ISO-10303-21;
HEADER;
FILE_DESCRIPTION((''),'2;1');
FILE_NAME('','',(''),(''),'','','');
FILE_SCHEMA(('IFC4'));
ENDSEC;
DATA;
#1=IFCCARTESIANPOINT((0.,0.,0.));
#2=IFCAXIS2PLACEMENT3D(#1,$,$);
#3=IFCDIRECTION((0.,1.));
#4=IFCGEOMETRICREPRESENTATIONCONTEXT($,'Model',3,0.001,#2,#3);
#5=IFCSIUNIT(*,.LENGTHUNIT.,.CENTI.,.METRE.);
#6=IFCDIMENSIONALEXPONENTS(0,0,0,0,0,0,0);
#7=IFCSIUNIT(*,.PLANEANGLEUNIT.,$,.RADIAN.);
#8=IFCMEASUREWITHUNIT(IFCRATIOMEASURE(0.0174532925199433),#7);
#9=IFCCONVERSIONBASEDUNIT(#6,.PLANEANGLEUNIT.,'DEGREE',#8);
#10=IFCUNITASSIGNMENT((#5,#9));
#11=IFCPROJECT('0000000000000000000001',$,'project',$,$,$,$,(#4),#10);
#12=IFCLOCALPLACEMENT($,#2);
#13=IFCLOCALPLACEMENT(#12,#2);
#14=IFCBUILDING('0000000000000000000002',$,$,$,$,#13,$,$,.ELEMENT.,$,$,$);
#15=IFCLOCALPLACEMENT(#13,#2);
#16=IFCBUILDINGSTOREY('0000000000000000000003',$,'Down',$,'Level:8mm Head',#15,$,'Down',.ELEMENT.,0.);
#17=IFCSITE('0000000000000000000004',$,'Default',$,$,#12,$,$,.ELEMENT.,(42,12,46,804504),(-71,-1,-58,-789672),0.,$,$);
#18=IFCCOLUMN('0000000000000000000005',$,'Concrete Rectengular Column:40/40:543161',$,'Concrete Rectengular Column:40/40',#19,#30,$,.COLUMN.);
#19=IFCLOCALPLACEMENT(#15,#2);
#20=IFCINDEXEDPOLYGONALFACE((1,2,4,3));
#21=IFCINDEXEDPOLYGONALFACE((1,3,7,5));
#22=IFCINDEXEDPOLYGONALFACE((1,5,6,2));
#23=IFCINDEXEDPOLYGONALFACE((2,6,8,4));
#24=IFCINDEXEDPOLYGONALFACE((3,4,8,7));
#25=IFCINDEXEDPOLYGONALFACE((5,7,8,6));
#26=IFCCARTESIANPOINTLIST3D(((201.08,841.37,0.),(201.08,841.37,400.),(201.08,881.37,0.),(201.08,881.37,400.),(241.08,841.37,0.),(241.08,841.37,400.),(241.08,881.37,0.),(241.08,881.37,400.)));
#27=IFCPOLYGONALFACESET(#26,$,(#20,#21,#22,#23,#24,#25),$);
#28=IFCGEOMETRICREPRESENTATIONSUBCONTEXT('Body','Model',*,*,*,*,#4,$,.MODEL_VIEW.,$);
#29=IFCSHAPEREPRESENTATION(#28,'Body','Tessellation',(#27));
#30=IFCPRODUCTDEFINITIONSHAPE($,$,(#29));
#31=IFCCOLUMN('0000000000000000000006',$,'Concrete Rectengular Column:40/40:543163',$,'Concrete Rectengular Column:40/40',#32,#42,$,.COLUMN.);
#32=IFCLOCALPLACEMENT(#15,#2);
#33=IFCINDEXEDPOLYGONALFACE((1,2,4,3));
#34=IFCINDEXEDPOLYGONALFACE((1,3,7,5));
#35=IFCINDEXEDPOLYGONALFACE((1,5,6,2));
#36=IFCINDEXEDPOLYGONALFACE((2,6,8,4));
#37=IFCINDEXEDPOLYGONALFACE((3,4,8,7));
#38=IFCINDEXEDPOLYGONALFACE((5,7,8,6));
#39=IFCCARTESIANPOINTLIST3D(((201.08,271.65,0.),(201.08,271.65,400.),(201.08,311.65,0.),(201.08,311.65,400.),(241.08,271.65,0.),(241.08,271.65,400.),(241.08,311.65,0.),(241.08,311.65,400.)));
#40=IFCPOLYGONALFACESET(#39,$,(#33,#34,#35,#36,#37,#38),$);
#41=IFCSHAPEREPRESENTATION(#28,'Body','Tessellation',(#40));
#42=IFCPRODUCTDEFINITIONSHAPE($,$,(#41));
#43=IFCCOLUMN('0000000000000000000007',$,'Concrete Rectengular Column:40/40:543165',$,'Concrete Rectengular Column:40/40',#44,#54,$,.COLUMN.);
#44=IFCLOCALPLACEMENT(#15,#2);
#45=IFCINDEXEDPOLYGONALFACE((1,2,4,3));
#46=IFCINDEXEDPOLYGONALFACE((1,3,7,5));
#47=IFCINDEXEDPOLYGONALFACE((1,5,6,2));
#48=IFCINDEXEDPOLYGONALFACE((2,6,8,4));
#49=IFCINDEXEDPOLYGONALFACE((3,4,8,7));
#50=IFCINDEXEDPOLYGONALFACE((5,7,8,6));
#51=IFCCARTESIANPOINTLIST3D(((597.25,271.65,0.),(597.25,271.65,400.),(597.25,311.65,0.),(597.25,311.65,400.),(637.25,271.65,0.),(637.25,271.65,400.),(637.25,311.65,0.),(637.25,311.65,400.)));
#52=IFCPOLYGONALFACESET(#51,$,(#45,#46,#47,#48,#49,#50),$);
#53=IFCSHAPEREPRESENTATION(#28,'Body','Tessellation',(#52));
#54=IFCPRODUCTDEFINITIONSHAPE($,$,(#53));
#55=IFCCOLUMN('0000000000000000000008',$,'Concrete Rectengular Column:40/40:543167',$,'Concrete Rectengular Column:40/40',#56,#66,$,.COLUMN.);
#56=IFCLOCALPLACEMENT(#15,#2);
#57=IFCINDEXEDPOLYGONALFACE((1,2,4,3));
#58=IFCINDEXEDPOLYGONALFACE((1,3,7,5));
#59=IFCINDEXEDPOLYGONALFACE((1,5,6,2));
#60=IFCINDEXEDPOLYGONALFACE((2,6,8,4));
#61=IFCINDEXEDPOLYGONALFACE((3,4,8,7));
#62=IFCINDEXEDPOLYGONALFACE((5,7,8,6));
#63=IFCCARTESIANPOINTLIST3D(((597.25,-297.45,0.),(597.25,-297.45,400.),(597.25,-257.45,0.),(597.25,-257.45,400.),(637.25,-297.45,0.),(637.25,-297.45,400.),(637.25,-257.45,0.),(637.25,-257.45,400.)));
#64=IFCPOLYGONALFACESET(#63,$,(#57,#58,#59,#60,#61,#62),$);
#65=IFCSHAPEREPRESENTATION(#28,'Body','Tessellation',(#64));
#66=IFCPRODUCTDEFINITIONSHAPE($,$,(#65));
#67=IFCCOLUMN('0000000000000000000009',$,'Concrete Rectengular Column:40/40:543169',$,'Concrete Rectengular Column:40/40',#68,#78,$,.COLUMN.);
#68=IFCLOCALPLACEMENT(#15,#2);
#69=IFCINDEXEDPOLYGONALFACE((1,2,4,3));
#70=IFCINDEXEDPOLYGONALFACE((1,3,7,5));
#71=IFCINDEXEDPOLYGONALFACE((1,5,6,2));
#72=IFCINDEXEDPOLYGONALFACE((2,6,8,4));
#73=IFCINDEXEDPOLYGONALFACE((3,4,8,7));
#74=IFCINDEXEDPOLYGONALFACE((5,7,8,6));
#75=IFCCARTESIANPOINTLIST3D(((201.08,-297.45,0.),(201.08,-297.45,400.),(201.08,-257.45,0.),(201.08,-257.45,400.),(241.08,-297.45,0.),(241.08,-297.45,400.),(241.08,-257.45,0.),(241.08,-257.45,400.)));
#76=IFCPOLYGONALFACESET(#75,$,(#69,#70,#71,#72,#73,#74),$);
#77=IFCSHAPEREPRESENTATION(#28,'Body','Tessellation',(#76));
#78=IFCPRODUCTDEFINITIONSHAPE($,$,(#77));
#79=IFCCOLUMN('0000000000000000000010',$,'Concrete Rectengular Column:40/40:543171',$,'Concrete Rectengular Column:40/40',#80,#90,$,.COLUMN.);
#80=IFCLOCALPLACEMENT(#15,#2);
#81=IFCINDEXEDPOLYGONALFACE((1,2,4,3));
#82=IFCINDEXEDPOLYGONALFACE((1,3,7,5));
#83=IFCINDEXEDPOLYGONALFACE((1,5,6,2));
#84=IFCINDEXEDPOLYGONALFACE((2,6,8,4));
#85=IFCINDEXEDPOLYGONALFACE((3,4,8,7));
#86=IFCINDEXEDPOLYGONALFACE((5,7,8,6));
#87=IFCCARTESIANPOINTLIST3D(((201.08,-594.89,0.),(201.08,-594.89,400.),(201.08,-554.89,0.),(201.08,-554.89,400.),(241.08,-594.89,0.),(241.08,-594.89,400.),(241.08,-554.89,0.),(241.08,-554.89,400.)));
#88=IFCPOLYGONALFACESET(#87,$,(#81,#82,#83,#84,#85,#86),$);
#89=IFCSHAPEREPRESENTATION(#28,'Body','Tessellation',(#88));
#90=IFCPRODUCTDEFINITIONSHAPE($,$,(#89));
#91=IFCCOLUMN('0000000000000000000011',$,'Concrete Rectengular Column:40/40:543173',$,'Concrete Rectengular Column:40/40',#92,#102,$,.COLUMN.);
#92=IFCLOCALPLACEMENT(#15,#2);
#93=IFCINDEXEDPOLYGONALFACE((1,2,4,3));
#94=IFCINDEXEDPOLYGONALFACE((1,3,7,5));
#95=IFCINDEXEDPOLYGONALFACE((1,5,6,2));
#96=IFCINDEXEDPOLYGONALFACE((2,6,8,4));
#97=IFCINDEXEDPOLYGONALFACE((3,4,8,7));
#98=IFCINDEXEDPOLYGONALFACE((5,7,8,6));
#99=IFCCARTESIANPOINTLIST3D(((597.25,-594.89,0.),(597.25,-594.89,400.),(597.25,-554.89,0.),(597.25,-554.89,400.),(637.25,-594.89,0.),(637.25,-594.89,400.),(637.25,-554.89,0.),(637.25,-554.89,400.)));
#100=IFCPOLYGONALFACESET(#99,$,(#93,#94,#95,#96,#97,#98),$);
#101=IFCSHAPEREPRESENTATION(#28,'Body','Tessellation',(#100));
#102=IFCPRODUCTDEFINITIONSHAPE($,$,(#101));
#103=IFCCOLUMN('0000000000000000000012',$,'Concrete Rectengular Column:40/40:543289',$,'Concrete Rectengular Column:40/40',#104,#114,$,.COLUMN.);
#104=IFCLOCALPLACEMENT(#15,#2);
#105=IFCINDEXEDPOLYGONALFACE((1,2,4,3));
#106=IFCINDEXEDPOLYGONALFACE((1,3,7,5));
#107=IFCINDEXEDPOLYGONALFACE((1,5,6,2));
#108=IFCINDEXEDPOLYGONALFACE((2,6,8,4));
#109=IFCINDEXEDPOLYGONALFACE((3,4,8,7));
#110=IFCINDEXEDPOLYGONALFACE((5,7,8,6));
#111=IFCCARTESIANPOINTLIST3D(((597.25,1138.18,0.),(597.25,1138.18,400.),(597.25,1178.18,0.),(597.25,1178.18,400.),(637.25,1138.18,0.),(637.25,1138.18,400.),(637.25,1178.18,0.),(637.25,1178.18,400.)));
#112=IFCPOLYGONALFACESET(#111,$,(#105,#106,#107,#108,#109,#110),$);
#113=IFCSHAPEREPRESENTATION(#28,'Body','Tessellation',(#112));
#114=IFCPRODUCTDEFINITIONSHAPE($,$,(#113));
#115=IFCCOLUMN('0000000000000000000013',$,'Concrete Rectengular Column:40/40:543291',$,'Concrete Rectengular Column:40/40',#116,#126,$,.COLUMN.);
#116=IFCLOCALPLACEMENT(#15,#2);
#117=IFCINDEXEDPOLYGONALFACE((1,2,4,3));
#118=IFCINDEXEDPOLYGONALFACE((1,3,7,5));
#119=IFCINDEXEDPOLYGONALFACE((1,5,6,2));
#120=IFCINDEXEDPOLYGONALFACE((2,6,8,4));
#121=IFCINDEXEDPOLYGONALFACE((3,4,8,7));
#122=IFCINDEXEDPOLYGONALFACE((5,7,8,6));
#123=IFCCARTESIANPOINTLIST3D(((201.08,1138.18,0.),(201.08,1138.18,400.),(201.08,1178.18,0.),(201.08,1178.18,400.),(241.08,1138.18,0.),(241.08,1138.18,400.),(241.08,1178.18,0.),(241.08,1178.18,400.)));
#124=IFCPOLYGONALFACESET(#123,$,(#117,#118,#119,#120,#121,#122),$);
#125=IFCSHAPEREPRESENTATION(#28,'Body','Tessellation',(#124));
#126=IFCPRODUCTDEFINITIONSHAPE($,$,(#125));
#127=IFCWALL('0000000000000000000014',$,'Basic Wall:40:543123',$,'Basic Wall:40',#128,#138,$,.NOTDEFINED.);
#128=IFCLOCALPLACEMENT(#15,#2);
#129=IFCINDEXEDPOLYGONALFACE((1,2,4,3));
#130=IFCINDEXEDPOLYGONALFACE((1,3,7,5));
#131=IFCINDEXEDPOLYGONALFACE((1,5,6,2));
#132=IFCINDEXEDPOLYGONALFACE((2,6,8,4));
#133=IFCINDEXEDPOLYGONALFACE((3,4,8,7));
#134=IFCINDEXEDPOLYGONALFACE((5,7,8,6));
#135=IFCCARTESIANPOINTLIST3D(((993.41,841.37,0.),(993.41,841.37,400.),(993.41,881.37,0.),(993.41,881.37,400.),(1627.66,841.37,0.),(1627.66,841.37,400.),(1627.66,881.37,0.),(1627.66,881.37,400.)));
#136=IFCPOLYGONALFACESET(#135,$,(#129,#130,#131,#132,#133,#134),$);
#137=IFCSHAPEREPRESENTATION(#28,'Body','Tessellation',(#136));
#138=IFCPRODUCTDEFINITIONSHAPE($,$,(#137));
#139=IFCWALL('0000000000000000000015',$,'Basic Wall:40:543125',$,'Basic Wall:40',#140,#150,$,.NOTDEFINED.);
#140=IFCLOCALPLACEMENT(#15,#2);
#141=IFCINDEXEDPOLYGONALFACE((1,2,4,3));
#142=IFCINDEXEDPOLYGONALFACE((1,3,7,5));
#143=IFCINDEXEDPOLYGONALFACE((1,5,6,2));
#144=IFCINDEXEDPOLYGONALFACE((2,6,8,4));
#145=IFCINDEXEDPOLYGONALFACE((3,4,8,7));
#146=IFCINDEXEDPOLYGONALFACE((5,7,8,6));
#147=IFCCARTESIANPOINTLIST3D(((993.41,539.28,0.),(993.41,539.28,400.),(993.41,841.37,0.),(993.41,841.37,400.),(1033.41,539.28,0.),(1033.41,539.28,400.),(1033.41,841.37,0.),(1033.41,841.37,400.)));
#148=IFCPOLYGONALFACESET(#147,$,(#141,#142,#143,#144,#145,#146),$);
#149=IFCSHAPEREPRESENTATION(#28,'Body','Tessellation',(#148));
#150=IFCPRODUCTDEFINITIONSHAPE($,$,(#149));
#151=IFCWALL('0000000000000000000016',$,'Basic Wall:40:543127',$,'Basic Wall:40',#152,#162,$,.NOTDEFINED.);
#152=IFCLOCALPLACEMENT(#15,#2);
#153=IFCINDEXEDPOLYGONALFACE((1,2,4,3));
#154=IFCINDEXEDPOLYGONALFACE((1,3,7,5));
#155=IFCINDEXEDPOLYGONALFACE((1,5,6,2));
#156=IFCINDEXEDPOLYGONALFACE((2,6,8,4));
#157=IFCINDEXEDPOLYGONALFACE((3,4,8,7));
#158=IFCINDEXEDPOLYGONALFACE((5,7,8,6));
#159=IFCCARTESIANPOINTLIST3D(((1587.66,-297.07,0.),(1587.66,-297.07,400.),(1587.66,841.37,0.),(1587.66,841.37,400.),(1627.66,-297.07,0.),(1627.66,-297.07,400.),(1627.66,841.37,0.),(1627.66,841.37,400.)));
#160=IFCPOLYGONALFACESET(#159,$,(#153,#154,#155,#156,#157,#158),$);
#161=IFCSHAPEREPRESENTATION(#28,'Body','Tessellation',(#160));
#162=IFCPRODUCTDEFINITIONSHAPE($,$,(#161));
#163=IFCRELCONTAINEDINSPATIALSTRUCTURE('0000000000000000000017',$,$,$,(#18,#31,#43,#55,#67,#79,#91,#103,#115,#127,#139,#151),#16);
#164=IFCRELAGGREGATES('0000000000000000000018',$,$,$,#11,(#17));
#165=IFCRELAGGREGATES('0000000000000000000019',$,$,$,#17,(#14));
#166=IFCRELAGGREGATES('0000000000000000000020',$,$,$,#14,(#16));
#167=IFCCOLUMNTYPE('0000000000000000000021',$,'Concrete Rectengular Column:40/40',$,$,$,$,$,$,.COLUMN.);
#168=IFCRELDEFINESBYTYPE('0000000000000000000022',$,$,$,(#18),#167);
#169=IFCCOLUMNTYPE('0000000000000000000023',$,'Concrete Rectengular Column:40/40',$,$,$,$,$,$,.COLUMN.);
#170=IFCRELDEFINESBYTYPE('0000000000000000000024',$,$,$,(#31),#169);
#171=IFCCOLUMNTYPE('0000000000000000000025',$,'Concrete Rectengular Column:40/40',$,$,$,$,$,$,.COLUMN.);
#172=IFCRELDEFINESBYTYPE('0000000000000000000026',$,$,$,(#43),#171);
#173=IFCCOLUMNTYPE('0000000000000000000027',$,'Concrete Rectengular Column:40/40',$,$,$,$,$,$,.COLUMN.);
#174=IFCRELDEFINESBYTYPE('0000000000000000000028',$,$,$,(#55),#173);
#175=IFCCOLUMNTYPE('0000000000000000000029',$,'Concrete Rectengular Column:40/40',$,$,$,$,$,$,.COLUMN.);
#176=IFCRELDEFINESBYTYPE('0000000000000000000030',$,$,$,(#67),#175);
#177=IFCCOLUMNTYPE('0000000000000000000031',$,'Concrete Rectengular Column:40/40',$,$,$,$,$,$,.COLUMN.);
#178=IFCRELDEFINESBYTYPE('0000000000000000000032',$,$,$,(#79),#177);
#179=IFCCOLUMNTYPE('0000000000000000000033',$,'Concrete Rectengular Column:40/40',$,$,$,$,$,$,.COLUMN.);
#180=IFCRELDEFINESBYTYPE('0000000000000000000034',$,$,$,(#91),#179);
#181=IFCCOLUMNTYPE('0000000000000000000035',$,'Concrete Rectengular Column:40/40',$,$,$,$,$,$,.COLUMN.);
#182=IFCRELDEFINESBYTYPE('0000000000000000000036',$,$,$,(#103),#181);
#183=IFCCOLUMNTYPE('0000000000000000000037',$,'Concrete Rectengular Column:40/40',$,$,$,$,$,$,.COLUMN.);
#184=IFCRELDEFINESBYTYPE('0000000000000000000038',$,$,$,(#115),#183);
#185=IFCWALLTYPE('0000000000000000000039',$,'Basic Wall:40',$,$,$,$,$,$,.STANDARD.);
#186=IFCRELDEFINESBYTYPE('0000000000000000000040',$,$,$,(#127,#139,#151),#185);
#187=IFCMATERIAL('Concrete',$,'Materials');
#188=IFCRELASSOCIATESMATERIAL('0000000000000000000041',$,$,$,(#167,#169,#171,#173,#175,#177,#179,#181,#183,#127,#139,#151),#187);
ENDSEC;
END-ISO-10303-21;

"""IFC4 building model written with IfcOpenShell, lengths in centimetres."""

from ifc_helpers import new_model, entity, si_unit, converted_unit, direction, frame, origin, place, context, subcontext, project, spatial, indexed_curve, outline, extrude, source, transform, mapped, material, type_object, type_shapes, element, save


model = new_model("IFC4")

# Units and contexts
model_context = context("Model", 3, precision=0.001, world=origin(), true_north=direction((0.0, 1.0)))
body_context = subcontext(model_context, "Body", "Model", "MODEL_VIEW")
ifc_project = project(units=[si_unit("LENGTHUNIT", "METRE", prefix="CENTI"), converted_unit("PLANEANGLEUNIT", "DEGREE", entity("IfcRatioMeasure", 0.0174532925199433), si_unit("PLANEANGLEUNIT", "RADIAN"), dimensions=[0, 0, 0, 0, 0, 0, 0])], contexts=[model_context])

# Site, building, storey
site_placement = place(None, origin())
site = spatial("IfcSite", under=ifc_project, at=site_placement, Name="Default", CompositionType="ELEMENT", RefLatitude=(42, 12, 46, 804504), RefLongitude=(-71, -1, -58, -789672), RefElevation=0.0)
building_placement = place(site_placement, origin())
building = spatial("IfcBuilding", under=site, at=building_placement, CompositionType="ELEMENT")
storey_placement = place(building_placement, origin())
storey = spatial("IfcBuildingStorey", under=building, at=storey_placement, Name="Down", ObjectType="Level:8mm Head", LongName="Down", CompositionType="ELEMENT", Elevation=0.0)

# Columns
ifc_material = material(Name="Concrete", Category="Materials")
column_type_1 = type_object("IfcColumnType", Name="Concrete Rectengular Column:40/40", PredefinedType="COLUMN", material=ifc_material)
shared_shape_1 = source(origin(), body_context, "Body", "SweptSolid", [
    extrude(outline(indexed_curve([(-20.0, -20.0), (20.0, -20.0), (20.0, 20.0), (-20.0, 20.0), (-20.0, -20.0)], self_intersect=False)), frame((221.08, 861.37, 0.0), z_axis=(0.0, 0.0, 1.0), x_axis=(0.0, -1.0, 0.0)), (0.0, 0.0, 1.0), 400.0),
])
type_shapes(column_type_1, [shared_shape_1])
column_1_placement = place(storey_placement, origin())
element("IfcColumn", 1, at=column_1_placement, inside=storey, type_object=column_type_1, Name="Concrete Rectengular Column:40/40:543161", ObjectType="Concrete Rectengular Column:40/40", PredefinedType="COLUMN", context=body_context, shape_type="MappedRepresentation", body=[
    mapped(shared_shape_1, transform((0.0, 0.0, 0.0), scale=1.0)),
])
column_type_2 = type_object("IfcColumnType", Name="Concrete Rectengular Column:40/40", PredefinedType="COLUMN", material=ifc_material)
shared_shape_2 = source(origin(), body_context, "Body", "SweptSolid", [
    extrude(outline(indexed_curve([(-20.0, -20.0), (20.0, -20.0), (20.0, 20.0), (-20.0, 20.0), (-20.0, -20.0)], self_intersect=False)), frame((221.08, 291.65, 0.0), z_axis=(0.0, 0.0, 1.0), x_axis=(0.0, -1.0, 0.0)), (0.0, 0.0, 1.0), 400.0),
])
type_shapes(column_type_2, [shared_shape_2])
column_2_placement = place(storey_placement, origin())
element("IfcColumn", 2, at=column_2_placement, inside=storey, type_object=column_type_2, Name="Concrete Rectengular Column:40/40:543163", ObjectType="Concrete Rectengular Column:40/40", PredefinedType="COLUMN", context=body_context, shape_type="MappedRepresentation", body=[
    mapped(shared_shape_2, transform((0.0, 0.0, 0.0), scale=1.0)),
])
column_type_3 = type_object("IfcColumnType", Name="Concrete Rectengular Column:40/40", PredefinedType="COLUMN", material=ifc_material)
shared_shape_3 = source(origin(), body_context, "Body", "SweptSolid", [
    extrude(outline(indexed_curve([(-20.0, -20.0), (20.0, -20.0), (20.0, 20.0), (-20.0, 20.0), (-20.0, -20.0)], self_intersect=False)), frame((617.25, 291.65, 0.0), z_axis=(0.0, 0.0, 1.0), x_axis=(0.0, -1.0, 0.0)), (0.0, 0.0, 1.0), 400.0),
])
type_shapes(column_type_3, [shared_shape_3])
column_3_placement = place(storey_placement, origin())
element("IfcColumn", 3, at=column_3_placement, inside=storey, type_object=column_type_3, Name="Concrete Rectengular Column:40/40:543165", ObjectType="Concrete Rectengular Column:40/40", PredefinedType="COLUMN", context=body_context, shape_type="MappedRepresentation", body=[
    mapped(shared_shape_3, transform((0.0, 0.0, 0.0), scale=1.0)),
])
column_type_4 = type_object("IfcColumnType", Name="Concrete Rectengular Column:40/40", PredefinedType="COLUMN", material=ifc_material)
shared_shape_4 = source(origin(), body_context, "Body", "SweptSolid", [
    extrude(outline(indexed_curve([(-20.0, -20.0), (20.0, -20.0), (20.0, 20.0), (-20.0, 20.0), (-20.0, -20.0)], self_intersect=False)), frame((617.25, -277.45, 0.0), z_axis=(0.0, 0.0, 1.0), x_axis=(0.0, -1.0, 0.0)), (0.0, 0.0, 1.0), 400.0),
])
type_shapes(column_type_4, [shared_shape_4])
column_4_placement = place(storey_placement, origin())
element("IfcColumn", 4, at=column_4_placement, inside=storey, type_object=column_type_4, Name="Concrete Rectengular Column:40/40:543167", ObjectType="Concrete Rectengular Column:40/40", PredefinedType="COLUMN", context=body_context, shape_type="MappedRepresentation", body=[
    mapped(shared_shape_4, transform((0.0, 0.0, 0.0), scale=1.0)),
])
column_type_5 = type_object("IfcColumnType", Name="Concrete Rectengular Column:40/40", PredefinedType="COLUMN", material=ifc_material)
shared_shape_5 = source(origin(), body_context, "Body", "SweptSolid", [
    extrude(outline(indexed_curve([(-20.0, -20.0), (20.0, -20.0), (20.0, 20.0), (-20.0, 20.0), (-20.0, -20.0)], self_intersect=False)), frame((221.08, -277.45, 0.0), z_axis=(0.0, 0.0, 1.0), x_axis=(0.0, -1.0, 0.0)), (0.0, 0.0, 1.0), 400.0),
])
type_shapes(column_type_5, [shared_shape_5])
column_5_placement = place(storey_placement, origin())
element("IfcColumn", 5, at=column_5_placement, inside=storey, type_object=column_type_5, Name="Concrete Rectengular Column:40/40:543169", ObjectType="Concrete Rectengular Column:40/40", PredefinedType="COLUMN", context=body_context, shape_type="MappedRepresentation", body=[
    mapped(shared_shape_5, transform((0.0, 0.0, 0.0), scale=1.0)),
])
column_type_6 = type_object("IfcColumnType", Name="Concrete Rectengular Column:40/40", PredefinedType="COLUMN", material=ifc_material)
shared_shape_6 = source(origin(), body_context, "Body", "SweptSolid", [
    extrude(outline(indexed_curve([(-20.0, -20.0), (20.0, -20.0), (20.0, 20.0), (-20.0, 20.0), (-20.0, -20.0)], self_intersect=False)), frame((221.08, -574.89, 0.0), z_axis=(0.0, 0.0, 1.0), x_axis=(0.0, -1.0, 0.0)), (0.0, 0.0, 1.0), 400.0),
])
type_shapes(column_type_6, [shared_shape_6])
column_6_placement = place(storey_placement, origin())
element("IfcColumn", 6, at=column_6_placement, inside=storey, type_object=column_type_6, Name="Concrete Rectengular Column:40/40:543171", ObjectType="Concrete Rectengular Column:40/40", PredefinedType="COLUMN", context=body_context, shape_type="MappedRepresentation", body=[
    mapped(shared_shape_6, transform((0.0, 0.0, 0.0), scale=1.0)),
])
column_type_7 = type_object("IfcColumnType", Name="Concrete Rectengular Column:40/40", PredefinedType="COLUMN", material=ifc_material)
shared_shape_7 = source(origin(), body_context, "Body", "SweptSolid", [
    extrude(outline(indexed_curve([(-20.0, -20.0), (20.0, -20.0), (20.0, 20.0), (-20.0, 20.0), (-20.0, -20.0)], self_intersect=False)), frame((617.25, -574.89, 0.0), z_axis=(0.0, 0.0, 1.0), x_axis=(0.0, -1.0, 0.0)), (0.0, 0.0, 1.0), 400.0),
])
type_shapes(column_type_7, [shared_shape_7])
column_7_placement = place(storey_placement, origin())
element("IfcColumn", 7, at=column_7_placement, inside=storey, type_object=column_type_7, Name="Concrete Rectengular Column:40/40:543173", ObjectType="Concrete Rectengular Column:40/40", PredefinedType="COLUMN", context=body_context, shape_type="MappedRepresentation", body=[
    mapped(shared_shape_7, transform((0.0, 0.0, 0.0), scale=1.0)),
])
column_type_8 = type_object("IfcColumnType", Name="Concrete Rectengular Column:40/40", PredefinedType="COLUMN", material=ifc_material)
shared_shape_8 = source(origin(), body_context, "Body", "SweptSolid", [
    extrude(outline(indexed_curve([(-20.0, -20.0), (20.0, -20.0), (20.0, 20.0), (-20.0, 20.0), (-20.0, -20.0)], self_intersect=False)), frame((617.25, 1158.18, 0.0), z_axis=(0.0, 0.0, 1.0), x_axis=(0.0, -1.0, 0.0)), (0.0, 0.0, 1.0), 400.0),
])
type_shapes(column_type_8, [shared_shape_8])
column_8_placement = place(storey_placement, origin())
element("IfcColumn", 8, at=column_8_placement, inside=storey, type_object=column_type_8, Name="Concrete Rectengular Column:40/40:543289", ObjectType="Concrete Rectengular Column:40/40", PredefinedType="COLUMN", context=body_context, shape_type="MappedRepresentation", body=[
    mapped(shared_shape_8, transform((0.0, 0.0, 0.0), scale=1.0)),
])
column_type_9 = type_object("IfcColumnType", Name="Concrete Rectengular Column:40/40", PredefinedType="COLUMN", material=ifc_material)
shared_shape_9 = source(origin(), body_context, "Body", "SweptSolid", [
    extrude(outline(indexed_curve([(-20.0, -20.0), (20.0, -20.0), (20.0, 20.0), (-20.0, 20.0), (-20.0, -20.0)], self_intersect=False)), frame((221.08, 1158.18, 0.0), z_axis=(0.0, 0.0, 1.0), x_axis=(0.0, -1.0, 0.0)), (0.0, 0.0, 1.0), 400.0),
])
type_shapes(column_type_9, [shared_shape_9])
column_9_placement = place(storey_placement, origin())
element("IfcColumn", 9, at=column_9_placement, inside=storey, type_object=column_type_9, Name="Concrete Rectengular Column:40/40:543291", ObjectType="Concrete Rectengular Column:40/40", PredefinedType="COLUMN", context=body_context, shape_type="MappedRepresentation", body=[
    mapped(shared_shape_9, transform((0.0, 0.0, 0.0), scale=1.0)),
])

# Walls
wall_type_1 = type_object("IfcWallType", Name="Basic Wall:40", PredefinedType="STANDARD")
wall_1_placement = place(storey_placement, frame((1627.66, 861.37, 0.0), z_axis=(0.0, 0.0, 1.0), x_axis=(-1.0, 0.0, 0.0)))
element("IfcWall", 10, at=wall_1_placement, inside=storey, type_object=wall_type_1, material=ifc_material, Name="Basic Wall:40:543123", ObjectType="Basic Wall:40", PredefinedType="NOTDEFINED", context=body_context, shape_type="SweptSolid", body=[
    extrude(outline(indexed_curve([(634.25, 20.0), (0.0, 20.0), (0.0, -20.0), (634.25, -20.0), (634.25, 20.0)], self_intersect=False)), origin(), (0.0, 0.0, 1.0), 400.0),
])
wall_2_placement = place(storey_placement, frame((1013.41, 841.37, 0.0), z_axis=(0.0, 0.0, 1.0), x_axis=(0.0, -1.0, 0.0)))
element("IfcWall", 11, at=wall_2_placement, inside=storey, type_object=wall_type_1, material=ifc_material, Name="Basic Wall:40:543125", ObjectType="Basic Wall:40", PredefinedType="NOTDEFINED", context=body_context, shape_type="SweptSolid", body=[
    extrude(outline(indexed_curve([(302.09, 20.0), (0.0, 20.0), (0.0, -20.0), (302.09, -20.0), (302.09, 20.0)], self_intersect=False)), origin(), (0.0, 0.0, 1.0), 400.0),
])
wall_3_placement = place(storey_placement, frame((1607.66, 841.37, 0.0), z_axis=(0.0, 0.0, 1.0), x_axis=(0.0, -1.0, 0.0)))
element("IfcWall", 12, at=wall_3_placement, inside=storey, type_object=wall_type_1, material=ifc_material, Name="Basic Wall:40:543127", ObjectType="Basic Wall:40", PredefinedType="NOTDEFINED", context=body_context, shape_type="SweptSolid", body=[
    extrude(outline(indexed_curve([(1138.44, 20.0), (0.0, 20.0), (0.0, -20.0), (1138.44, -20.0), (1138.44, 20.0)], self_intersect=False)), origin(), (0.0, 0.0, 1.0), 400.0),
])

save(model, "model.ifc")
